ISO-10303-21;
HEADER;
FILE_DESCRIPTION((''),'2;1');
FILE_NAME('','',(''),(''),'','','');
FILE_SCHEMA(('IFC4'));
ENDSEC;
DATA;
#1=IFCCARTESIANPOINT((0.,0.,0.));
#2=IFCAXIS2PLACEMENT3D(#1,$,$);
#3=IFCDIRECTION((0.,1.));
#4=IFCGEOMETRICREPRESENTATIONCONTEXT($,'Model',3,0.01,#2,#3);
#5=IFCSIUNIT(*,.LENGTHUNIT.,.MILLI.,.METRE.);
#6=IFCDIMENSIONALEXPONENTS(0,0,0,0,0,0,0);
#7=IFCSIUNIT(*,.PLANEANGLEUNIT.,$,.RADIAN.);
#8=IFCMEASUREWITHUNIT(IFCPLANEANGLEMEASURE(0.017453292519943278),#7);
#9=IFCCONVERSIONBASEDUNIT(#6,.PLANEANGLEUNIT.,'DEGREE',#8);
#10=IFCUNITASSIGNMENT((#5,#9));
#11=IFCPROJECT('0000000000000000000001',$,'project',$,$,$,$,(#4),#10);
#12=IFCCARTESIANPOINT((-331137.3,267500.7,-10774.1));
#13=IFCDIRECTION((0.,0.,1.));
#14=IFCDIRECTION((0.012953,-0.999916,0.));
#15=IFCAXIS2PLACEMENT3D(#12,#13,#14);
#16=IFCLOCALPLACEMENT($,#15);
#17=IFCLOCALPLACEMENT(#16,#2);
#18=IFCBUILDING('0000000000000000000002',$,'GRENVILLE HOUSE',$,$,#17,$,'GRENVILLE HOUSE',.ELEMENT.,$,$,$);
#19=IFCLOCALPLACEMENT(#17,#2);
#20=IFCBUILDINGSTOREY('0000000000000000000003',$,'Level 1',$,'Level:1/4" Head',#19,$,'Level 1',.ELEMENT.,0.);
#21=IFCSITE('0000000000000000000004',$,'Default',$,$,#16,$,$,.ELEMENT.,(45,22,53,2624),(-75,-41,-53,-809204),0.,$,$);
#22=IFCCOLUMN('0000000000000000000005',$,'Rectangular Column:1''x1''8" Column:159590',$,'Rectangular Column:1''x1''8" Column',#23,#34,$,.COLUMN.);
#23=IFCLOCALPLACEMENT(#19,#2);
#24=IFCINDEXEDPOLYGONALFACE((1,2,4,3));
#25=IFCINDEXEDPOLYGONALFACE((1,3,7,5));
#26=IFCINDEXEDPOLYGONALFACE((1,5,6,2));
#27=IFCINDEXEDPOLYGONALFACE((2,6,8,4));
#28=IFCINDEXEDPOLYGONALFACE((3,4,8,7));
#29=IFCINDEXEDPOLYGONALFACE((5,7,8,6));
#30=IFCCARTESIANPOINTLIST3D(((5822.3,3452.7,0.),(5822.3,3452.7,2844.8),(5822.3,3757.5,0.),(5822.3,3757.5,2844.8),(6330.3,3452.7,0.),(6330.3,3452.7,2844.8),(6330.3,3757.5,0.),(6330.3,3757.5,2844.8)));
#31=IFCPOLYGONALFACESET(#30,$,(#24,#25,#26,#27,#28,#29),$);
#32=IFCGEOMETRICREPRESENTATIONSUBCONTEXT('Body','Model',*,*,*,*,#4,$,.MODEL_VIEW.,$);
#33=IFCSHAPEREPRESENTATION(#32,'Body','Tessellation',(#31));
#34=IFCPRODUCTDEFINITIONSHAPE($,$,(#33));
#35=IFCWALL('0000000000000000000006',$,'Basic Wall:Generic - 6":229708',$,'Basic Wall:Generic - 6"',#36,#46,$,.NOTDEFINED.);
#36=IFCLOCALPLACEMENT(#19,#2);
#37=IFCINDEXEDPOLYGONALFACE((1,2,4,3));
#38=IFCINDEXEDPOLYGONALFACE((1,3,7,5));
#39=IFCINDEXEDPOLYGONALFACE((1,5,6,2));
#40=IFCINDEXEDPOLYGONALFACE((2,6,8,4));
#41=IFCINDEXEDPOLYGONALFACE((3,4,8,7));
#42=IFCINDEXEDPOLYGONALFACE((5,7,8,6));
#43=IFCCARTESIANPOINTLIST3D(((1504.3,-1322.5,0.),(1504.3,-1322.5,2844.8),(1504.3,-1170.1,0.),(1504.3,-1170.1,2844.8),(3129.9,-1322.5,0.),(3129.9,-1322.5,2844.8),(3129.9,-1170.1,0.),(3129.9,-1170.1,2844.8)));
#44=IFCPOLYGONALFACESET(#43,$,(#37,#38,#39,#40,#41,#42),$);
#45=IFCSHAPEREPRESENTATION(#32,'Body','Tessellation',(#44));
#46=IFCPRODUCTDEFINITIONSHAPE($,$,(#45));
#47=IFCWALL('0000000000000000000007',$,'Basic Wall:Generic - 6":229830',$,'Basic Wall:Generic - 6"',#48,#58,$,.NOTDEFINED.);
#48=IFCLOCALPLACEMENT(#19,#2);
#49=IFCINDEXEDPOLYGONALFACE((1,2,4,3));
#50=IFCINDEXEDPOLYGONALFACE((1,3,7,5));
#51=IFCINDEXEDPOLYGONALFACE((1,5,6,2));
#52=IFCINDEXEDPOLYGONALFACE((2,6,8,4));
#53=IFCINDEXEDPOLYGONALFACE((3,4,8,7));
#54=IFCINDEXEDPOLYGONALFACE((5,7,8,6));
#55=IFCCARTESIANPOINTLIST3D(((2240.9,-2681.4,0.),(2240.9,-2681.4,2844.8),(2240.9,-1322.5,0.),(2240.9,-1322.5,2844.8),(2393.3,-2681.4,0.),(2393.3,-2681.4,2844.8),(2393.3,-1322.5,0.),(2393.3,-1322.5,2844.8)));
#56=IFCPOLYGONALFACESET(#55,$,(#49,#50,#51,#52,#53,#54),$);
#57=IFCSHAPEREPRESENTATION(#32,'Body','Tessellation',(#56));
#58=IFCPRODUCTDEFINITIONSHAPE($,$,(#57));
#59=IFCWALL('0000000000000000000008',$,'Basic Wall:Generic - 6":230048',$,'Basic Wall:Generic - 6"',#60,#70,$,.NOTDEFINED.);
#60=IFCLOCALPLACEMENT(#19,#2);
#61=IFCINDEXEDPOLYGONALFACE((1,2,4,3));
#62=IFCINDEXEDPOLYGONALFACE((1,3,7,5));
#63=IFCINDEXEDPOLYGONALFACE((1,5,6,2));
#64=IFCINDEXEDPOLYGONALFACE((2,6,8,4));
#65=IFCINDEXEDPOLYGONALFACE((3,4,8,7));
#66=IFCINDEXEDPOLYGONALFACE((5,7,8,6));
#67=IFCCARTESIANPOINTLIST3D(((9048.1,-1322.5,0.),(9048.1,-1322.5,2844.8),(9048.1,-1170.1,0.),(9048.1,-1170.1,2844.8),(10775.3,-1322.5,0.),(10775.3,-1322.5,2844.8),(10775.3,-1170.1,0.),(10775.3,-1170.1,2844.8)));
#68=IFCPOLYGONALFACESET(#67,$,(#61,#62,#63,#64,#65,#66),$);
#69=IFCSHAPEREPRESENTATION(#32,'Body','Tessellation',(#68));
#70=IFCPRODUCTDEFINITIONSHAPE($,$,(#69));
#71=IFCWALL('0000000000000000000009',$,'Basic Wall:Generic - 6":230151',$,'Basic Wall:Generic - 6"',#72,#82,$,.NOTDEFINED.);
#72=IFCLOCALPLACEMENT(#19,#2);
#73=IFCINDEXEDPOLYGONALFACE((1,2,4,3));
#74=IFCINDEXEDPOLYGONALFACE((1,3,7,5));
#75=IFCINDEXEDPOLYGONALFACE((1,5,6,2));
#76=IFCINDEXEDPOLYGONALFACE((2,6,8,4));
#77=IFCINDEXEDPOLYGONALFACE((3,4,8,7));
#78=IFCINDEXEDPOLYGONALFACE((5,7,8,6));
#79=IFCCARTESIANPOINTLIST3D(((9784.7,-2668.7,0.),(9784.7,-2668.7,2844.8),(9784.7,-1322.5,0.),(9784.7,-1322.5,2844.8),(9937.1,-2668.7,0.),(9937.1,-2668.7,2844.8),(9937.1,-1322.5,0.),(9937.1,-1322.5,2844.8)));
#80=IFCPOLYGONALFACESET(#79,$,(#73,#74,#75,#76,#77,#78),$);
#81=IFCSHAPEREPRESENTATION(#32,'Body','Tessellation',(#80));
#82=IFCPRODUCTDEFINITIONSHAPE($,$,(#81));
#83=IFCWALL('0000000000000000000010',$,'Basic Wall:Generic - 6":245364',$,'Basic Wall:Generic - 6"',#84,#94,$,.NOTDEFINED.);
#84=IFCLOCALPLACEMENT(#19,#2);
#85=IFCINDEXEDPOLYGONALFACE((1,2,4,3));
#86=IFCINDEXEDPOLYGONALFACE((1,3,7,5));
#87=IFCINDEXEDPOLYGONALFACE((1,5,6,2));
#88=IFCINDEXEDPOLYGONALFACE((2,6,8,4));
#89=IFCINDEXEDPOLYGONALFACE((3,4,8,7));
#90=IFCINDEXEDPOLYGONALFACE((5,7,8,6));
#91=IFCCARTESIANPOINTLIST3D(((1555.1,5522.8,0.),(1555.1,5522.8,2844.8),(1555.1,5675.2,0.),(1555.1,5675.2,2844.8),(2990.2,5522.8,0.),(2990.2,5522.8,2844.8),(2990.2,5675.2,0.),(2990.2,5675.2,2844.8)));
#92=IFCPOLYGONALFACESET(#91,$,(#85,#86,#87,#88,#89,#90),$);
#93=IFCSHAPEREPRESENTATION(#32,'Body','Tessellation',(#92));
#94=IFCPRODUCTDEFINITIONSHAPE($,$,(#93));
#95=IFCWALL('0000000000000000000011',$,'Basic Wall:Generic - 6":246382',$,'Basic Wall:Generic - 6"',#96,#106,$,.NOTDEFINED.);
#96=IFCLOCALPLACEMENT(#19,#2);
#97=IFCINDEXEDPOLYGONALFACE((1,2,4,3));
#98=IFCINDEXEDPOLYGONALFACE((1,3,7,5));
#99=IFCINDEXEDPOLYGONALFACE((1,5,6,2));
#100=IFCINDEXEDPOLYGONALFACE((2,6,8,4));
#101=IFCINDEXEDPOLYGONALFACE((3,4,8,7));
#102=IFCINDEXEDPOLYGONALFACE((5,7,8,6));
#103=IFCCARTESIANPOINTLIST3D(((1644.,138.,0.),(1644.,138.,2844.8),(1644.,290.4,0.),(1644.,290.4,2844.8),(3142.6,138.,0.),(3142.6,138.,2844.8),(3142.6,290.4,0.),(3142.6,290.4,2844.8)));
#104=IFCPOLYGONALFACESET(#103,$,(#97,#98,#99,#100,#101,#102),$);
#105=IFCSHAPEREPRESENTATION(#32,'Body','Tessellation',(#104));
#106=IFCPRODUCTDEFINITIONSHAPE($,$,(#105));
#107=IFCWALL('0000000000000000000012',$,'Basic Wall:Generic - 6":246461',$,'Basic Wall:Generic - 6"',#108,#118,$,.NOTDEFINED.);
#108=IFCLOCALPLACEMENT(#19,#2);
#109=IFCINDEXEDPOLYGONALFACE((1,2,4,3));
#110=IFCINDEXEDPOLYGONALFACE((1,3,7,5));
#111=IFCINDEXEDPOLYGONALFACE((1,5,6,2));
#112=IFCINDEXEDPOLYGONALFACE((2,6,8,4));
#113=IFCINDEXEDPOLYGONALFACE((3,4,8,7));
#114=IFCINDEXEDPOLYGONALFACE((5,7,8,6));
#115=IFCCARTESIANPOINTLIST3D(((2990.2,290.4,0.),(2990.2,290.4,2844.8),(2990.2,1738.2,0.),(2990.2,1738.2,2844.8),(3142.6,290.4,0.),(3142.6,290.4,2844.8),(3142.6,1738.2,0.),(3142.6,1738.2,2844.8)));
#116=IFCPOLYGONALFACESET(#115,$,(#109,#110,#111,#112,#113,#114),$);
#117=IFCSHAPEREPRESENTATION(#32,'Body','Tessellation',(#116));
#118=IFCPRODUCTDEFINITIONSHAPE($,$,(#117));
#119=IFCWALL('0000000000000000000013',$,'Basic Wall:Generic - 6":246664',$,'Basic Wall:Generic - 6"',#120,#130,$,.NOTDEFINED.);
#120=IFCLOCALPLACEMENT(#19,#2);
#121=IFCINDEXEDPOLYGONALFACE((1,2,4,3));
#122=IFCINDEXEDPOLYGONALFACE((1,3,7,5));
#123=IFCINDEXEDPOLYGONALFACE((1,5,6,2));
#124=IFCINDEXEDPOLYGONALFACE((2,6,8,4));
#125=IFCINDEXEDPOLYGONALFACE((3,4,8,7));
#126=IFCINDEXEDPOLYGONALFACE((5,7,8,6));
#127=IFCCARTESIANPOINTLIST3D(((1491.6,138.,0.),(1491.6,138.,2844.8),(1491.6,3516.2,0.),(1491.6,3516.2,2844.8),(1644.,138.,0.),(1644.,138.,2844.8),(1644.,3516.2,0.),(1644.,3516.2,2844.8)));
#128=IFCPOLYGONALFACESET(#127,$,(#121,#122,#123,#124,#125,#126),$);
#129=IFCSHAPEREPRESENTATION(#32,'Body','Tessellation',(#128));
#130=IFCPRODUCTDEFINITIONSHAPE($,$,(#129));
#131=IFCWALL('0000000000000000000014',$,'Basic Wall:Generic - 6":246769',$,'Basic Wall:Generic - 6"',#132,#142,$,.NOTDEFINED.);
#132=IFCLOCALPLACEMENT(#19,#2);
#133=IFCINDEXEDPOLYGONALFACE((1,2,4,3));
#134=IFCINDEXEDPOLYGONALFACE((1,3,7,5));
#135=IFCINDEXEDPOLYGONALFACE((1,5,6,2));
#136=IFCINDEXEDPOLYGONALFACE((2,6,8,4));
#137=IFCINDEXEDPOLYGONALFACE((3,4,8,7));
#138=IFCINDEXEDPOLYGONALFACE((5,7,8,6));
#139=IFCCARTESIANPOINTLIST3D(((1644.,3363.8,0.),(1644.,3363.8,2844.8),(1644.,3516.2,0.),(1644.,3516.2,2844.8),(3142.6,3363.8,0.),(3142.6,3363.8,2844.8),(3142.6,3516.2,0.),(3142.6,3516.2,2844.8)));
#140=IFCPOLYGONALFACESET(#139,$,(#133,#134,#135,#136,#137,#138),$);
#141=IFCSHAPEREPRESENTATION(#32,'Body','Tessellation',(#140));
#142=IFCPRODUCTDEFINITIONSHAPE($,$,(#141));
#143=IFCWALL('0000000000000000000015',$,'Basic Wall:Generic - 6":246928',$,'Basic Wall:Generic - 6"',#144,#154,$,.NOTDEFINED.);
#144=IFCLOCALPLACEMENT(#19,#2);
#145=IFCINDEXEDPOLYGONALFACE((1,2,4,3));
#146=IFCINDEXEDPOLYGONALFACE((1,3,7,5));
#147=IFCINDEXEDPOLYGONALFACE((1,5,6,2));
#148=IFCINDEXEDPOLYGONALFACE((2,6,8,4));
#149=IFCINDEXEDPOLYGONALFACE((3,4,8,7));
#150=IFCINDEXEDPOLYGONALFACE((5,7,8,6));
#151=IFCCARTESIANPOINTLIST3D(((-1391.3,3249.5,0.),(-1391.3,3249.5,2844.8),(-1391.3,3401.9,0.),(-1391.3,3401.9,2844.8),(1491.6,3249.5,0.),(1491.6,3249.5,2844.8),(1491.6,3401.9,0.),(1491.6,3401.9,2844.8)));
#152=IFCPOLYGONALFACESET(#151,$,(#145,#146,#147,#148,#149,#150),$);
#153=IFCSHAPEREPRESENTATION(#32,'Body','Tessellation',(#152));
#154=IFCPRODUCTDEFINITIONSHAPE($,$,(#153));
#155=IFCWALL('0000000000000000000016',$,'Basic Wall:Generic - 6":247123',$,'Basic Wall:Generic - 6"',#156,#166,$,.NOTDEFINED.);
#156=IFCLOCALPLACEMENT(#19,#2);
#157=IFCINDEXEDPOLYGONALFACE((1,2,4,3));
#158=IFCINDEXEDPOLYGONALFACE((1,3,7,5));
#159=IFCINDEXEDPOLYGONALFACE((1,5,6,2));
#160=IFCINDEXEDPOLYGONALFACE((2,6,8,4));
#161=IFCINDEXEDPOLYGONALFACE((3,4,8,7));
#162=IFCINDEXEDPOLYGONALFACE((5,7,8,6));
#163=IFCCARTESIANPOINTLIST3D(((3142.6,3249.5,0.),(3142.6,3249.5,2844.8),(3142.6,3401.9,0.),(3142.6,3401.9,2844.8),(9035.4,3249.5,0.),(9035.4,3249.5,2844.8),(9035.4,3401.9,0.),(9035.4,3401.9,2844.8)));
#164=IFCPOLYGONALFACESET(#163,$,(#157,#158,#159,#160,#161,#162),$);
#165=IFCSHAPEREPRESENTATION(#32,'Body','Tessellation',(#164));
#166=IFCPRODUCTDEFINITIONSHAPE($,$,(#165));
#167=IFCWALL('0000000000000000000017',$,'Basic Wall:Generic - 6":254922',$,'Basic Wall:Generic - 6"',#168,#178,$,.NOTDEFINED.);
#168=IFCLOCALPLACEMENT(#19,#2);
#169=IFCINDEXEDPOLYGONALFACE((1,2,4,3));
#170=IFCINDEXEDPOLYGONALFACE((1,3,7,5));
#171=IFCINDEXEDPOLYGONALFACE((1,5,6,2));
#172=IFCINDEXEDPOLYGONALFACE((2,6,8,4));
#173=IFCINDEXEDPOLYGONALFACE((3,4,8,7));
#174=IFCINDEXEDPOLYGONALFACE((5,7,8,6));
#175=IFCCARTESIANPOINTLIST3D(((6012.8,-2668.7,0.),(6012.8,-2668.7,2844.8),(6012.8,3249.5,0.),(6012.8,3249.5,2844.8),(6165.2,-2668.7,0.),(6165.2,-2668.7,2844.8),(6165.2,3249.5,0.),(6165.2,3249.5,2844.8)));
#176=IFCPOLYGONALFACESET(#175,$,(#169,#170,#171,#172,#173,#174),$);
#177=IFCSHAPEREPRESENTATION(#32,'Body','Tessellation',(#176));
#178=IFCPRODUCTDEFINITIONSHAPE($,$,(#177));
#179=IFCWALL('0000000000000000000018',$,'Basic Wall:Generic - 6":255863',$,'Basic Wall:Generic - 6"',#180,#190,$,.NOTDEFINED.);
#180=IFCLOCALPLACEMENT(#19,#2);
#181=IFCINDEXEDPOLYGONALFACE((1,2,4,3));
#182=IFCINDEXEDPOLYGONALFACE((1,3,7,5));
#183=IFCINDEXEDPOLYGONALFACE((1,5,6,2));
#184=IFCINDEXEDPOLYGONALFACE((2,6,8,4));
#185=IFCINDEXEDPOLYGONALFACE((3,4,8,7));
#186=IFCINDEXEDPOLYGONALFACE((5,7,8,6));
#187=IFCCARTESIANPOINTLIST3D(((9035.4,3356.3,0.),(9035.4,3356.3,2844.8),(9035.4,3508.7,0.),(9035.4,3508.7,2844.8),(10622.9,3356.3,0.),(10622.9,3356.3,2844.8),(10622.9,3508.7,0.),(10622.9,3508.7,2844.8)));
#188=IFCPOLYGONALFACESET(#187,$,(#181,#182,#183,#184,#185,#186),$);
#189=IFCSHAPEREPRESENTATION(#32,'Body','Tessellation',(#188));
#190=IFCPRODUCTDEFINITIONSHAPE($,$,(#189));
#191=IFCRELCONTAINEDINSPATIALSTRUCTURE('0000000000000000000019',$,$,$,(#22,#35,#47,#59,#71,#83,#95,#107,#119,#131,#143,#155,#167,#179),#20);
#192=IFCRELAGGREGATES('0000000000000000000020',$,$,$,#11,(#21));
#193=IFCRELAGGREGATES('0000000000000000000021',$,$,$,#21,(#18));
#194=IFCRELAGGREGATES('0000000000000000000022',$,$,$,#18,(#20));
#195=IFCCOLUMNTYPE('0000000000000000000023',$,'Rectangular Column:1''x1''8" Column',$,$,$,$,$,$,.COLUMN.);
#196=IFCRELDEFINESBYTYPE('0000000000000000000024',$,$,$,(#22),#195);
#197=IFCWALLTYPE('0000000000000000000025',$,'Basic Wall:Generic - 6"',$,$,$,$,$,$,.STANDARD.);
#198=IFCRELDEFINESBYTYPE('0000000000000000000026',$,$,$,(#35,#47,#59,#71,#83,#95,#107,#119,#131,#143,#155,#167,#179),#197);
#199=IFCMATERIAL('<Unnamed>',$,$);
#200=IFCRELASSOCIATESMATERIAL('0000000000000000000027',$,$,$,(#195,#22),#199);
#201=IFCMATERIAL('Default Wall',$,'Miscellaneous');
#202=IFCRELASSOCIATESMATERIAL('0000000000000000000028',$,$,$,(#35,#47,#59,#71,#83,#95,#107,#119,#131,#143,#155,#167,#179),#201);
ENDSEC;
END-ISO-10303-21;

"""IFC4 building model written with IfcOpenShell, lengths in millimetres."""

from ifc_helpers import new_model, entity, si_unit, converted_unit, direction, frame, origin, place, context, subcontext, project, spatial, indexed_curve, outline, extrude, source, transform, mapped, material, type_object, type_shapes, element, save


model = new_model("IFC4")

# Units and contexts
model_context = context("Model", 3, precision=0.01, world=origin(), true_north=direction((0.0, 1.0)))
body_context = subcontext(model_context, "Body", "Model", "MODEL_VIEW")
ifc_project = project(units=[si_unit("LENGTHUNIT", "METRE", prefix="MILLI"), converted_unit("PLANEANGLEUNIT", "DEGREE", entity("IfcPlaneAngleMeasure", 0.017453292519943278), si_unit("PLANEANGLEUNIT", "RADIAN"), dimensions=[0, 0, 0, 0, 0, 0, 0])], contexts=[model_context])

# Site, building, storey
site_placement = place(None, frame((-331137.3, 267500.7, -10774.1), z_axis=(0.0, 0.0, 1.0), x_axis=(0.012953, -0.999916, 0.0)))
site = spatial("IfcSite", under=ifc_project, at=site_placement, Name="Default", CompositionType="ELEMENT", RefLatitude=(45, 22, 53, 2624), RefLongitude=(-75, -41, -53, -809204), RefElevation=0.0)
building_placement = place(site_placement, origin())
building = spatial("IfcBuilding", under=site, at=building_placement, Name="GRENVILLE HOUSE", LongName="GRENVILLE HOUSE", CompositionType="ELEMENT")
storey_placement = place(building_placement, origin())
storey = spatial("IfcBuildingStorey", under=building, at=storey_placement, Name="Level 1", ObjectType="Level:1/4\" Head", LongName="Level 1", CompositionType="ELEMENT", Elevation=0.0)

# Column
ifc_material_1 = material(Name="<Unnamed>")
column_type = type_object("IfcColumnType", Name="Rectangular Column:1'x1'8\" Column", PredefinedType="COLUMN", material=ifc_material_1)
shared_shape = source(origin(), body_context, "Body", "SweptSolid", [
    extrude(outline(indexed_curve([(-254.0, -152.4), (254.0, -152.4), (254.0, 152.4), (-254.0, 152.4), (-254.0, -152.4)], self_intersect=False)), frame((0.0, 0.0, 0.0), z_axis=(0.0, 0.0, 1.0), x_axis=(-1.0, 0.0, 0.0)), (0.0, 0.0, 1.0), 2844.8),
])
type_shapes(column_type, [shared_shape])
column_placement = place(storey_placement, frame((6076.3, 3605.1, 0.0)))
element("IfcColumn", 1, at=column_placement, inside=storey, type_object=column_type, material=ifc_material_1, Name="Rectangular Column:1'x1'8\" Column:159590", ObjectType="Rectangular Column:1'x1'8\" Column", PredefinedType="COLUMN", context=body_context, shape_type="MappedRepresentation", body=[
    mapped(shared_shape, transform((0.0, 0.0, 0.0), scale=1.0)),
])

# Walls
ifc_material_2 = material(Name="Default Wall", Category="Miscellaneous")
wall_type_1 = type_object("IfcWallType", Name="Basic Wall:Generic - 6\"", PredefinedType="STANDARD")
wall_1_placement = place(storey_placement, frame((1504.3, -1246.3, 0.0)))
element("IfcWall", 2, at=wall_1_placement, inside=storey, type_object=wall_type_1, material=ifc_material_2, Name="Basic Wall:Generic - 6\":229708", ObjectType="Basic Wall:Generic - 6\"", PredefinedType="NOTDEFINED", context=body_context, shape_type="SweptSolid", body=[
    extrude(outline(indexed_curve([(1625.6, 76.2), (0.0, 76.2), (0.0, -76.2), (1625.6, -76.2), (1625.6, 76.2)], self_intersect=False)), origin(), (0.0, 0.0, 1.0), 2844.8),
])
wall_2_placement = place(storey_placement, frame((2317.1, -1322.5, 0.0), z_axis=(0.0, 0.0, 1.0), x_axis=(0.0, -1.0, 0.0)))
element("IfcWall", 3, at=wall_2_placement, inside=storey, type_object=wall_type_1, material=ifc_material_2, Name="Basic Wall:Generic - 6\":229830", ObjectType="Basic Wall:Generic - 6\"", PredefinedType="NOTDEFINED", context=body_context, shape_type="SweptSolid", body=[
    extrude(outline(indexed_curve([(1358.9, 76.2), (0.0, 76.2), (0.0, -76.2), (1358.9, -76.2), (1358.9, 76.2)], self_intersect=False)), origin(), (0.0, 0.0, 1.0), 2844.8),
])
wall_3_placement = place(storey_placement, frame((9048.1, -1246.3, 0.0)))
element("IfcWall", 4, at=wall_3_placement, inside=storey, type_object=wall_type_1, material=ifc_material_2, Name="Basic Wall:Generic - 6\":230048", ObjectType="Basic Wall:Generic - 6\"", PredefinedType="NOTDEFINED", context=body_context, shape_type="SweptSolid", body=[
    extrude(outline(indexed_curve([(1727.2, 76.2), (0.0, 76.2), (0.0, -76.2), (1727.2, -76.2), (1727.2, 76.2)], self_intersect=False)), origin(), (0.0, 0.0, 1.0), 2844.8),
])
wall_4_placement = place(storey_placement, frame((9860.9, -1322.5, 0.0), z_axis=(0.0, 0.0, 1.0), x_axis=(0.0, -1.0, 0.0)))
element("IfcWall", 5, at=wall_4_placement, inside=storey, type_object=wall_type_1, material=ifc_material_2, Name="Basic Wall:Generic - 6\":230151", ObjectType="Basic Wall:Generic - 6\"", PredefinedType="NOTDEFINED", context=body_context, shape_type="SweptSolid", body=[
    extrude(outline(indexed_curve([(1346.2, 76.2), (0.0, 76.2), (0.0, -76.2), (1346.2, -76.2), (1346.2, 76.2)], self_intersect=False)), origin(), (0.0, 0.0, 1.0), 2844.8),
])
wall_5_placement = place(storey_placement, frame((2990.2, 5599.0, 0.0), z_axis=(0.0, 0.0, 1.0), x_axis=(-1.0, 0.0, 0.0)))
element("IfcWall", 6, at=wall_5_placement, inside=storey, type_object=wall_type_1, material=ifc_material_2, Name="Basic Wall:Generic - 6\":245364", ObjectType="Basic Wall:Generic - 6\"", PredefinedType="NOTDEFINED", context=body_context, shape_type="SweptSolid", body=[
    extrude(outline(indexed_curve([(1435.1, 76.2), (0.0, 76.2), (0.0, -76.2), (1435.1, -76.2), (1435.1, 76.2)], self_intersect=False)), origin(), (0.0, 0.0, 1.0), 2844.8),
])
wall_6_placement = place(storey_placement, frame((1644.0, 214.2, 0.0)))
element("IfcWall", 7, at=wall_6_placement, inside=storey, type_object=wall_type_1, material=ifc_material_2, Name="Basic Wall:Generic - 6\":246382", ObjectType="Basic Wall:Generic - 6\"", PredefinedType="NOTDEFINED", context=body_context, shape_type="SweptSolid", body=[
    extrude(outline(indexed_curve([(1498.6, 76.2), (0.0, 76.2), (0.0, -76.2), (1498.6, -76.2), (1498.6, 76.2)], self_intersect=False)), origin(), (0.0, 0.0, 1.0), 2844.8),
])
wall_7_placement = place(storey_placement, frame((3066.4, 290.4, 0.0), z_axis=(0.0, 0.0, 1.0), x_axis=(0.0, 1.0, 0.0)))
element("IfcWall", 8, at=wall_7_placement, inside=storey, type_object=wall_type_1, material=ifc_material_2, Name="Basic Wall:Generic - 6\":246461", ObjectType="Basic Wall:Generic - 6\"", PredefinedType="NOTDEFINED", context=body_context, shape_type="SweptSolid", body=[
    extrude(outline(indexed_curve([(1447.8, 76.2), (0.0, 76.2), (0.0, -76.2), (1447.8, -76.2), (1447.8, 76.2)], self_intersect=False)), origin(), (0.0, 0.0, 1.0), 2844.8),
])
wall_8_placement = place(storey_placement, frame((1567.8, 138.0, 0.0), z_axis=(0.0, 0.0, 1.0), x_axis=(0.0, 1.0, 0.0)))
element("IfcWall", 9, at=wall_8_placement, inside=storey, type_object=wall_type_1, material=ifc_material_2, Name="Basic Wall:Generic - 6\":246664", ObjectType="Basic Wall:Generic - 6\"", PredefinedType="NOTDEFINED", context=body_context, shape_type="SweptSolid", body=[
    extrude(outline(indexed_curve([(3378.2, 76.2), (0.0, 76.2), (0.0, -76.2), (3378.2, -76.2), (3378.2, 76.2)], self_intersect=False)), origin(), (0.0, 0.0, 1.0), 2844.8),
])
wall_9_placement = place(storey_placement, frame((1644.0, 3440.0, 0.0)))
element("IfcWall", 10, at=wall_9_placement, inside=storey, type_object=wall_type_1, material=ifc_material_2, Name="Basic Wall:Generic - 6\":246769", ObjectType="Basic Wall:Generic - 6\"", PredefinedType="NOTDEFINED", context=body_context, shape_type="SweptSolid", body=[
    extrude(outline(indexed_curve([(1498.6, 76.2), (0.0, 76.2), (0.0, -76.2), (1498.6, -76.2), (1498.6, 76.2)], self_intersect=False)), origin(), (0.0, 0.0, 1.0), 2844.8),
])
wall_10_placement = place(storey_placement, frame((1491.6, 3325.7, 0.0), z_axis=(0.0, 0.0, 1.0), x_axis=(-1.0, 0.0, 0.0)))
element("IfcWall", 11, at=wall_10_placement, inside=storey, type_object=wall_type_1, material=ifc_material_2, Name="Basic Wall:Generic - 6\":246928", ObjectType="Basic Wall:Generic - 6\"", PredefinedType="NOTDEFINED", context=body_context, shape_type="SweptSolid", body=[
    extrude(outline(indexed_curve([(2882.9, 76.2), (0.0, 76.2), (0.0, -76.2), (2882.9, -76.2), (2882.9, 76.2)], self_intersect=False)), origin(), (0.0, 0.0, 1.0), 2844.8),
])
wall_11_placement = place(storey_placement, frame((3142.6, 3325.7, 0.0)))
element("IfcWall", 12, at=wall_11_placement, inside=storey, type_object=wall_type_1, material=ifc_material_2, Name="Basic Wall:Generic - 6\":247123", ObjectType="Basic Wall:Generic - 6\"", PredefinedType="NOTDEFINED", context=body_context, shape_type="SweptSolid", body=[
    extrude(outline(indexed_curve([(5892.8, 76.2), (0.0, 76.2), (0.0, -76.2), (5892.8, -76.2), (5892.8, 76.2)], self_intersect=False)), origin(), (0.0, 0.0, 1.0), 2844.8),
])
wall_12_placement = place(storey_placement, frame((6089.0, 3249.5, 0.0), z_axis=(0.0, 0.0, 1.0), x_axis=(0.0, -1.0, 0.0)))
element("IfcWall", 13, at=wall_12_placement, inside=storey, type_object=wall_type_1, material=ifc_material_2, Name="Basic Wall:Generic - 6\":254922", ObjectType="Basic Wall:Generic - 6\"", PredefinedType="NOTDEFINED", context=body_context, shape_type="SweptSolid", body=[
    extrude(outline(indexed_curve([(5918.2, 76.2), (0.0, 76.2), (0.0, -76.2), (5918.2, -76.2), (5918.2, 76.2)], self_intersect=False)), origin(), (0.0, 0.0, 1.0), 2844.8),
])
wall_13_placement = place(storey_placement, frame((9035.4, 3432.5, 0.0)))
element("IfcWall", 14, at=wall_13_placement, inside=storey, type_object=wall_type_1, material=ifc_material_2, Name="Basic Wall:Generic - 6\":255863", ObjectType="Basic Wall:Generic - 6\"", PredefinedType="NOTDEFINED", context=body_context, shape_type="SweptSolid", body=[
    extrude(outline(indexed_curve([(1587.5, 76.2), (0.0, 76.2), (0.0, -76.2), (1587.5, -76.2), (1587.5, 76.2)], self_intersect=False)), origin(), (0.0, 0.0, 1.0), 2844.8),
])

save(model, "model.ifc")
